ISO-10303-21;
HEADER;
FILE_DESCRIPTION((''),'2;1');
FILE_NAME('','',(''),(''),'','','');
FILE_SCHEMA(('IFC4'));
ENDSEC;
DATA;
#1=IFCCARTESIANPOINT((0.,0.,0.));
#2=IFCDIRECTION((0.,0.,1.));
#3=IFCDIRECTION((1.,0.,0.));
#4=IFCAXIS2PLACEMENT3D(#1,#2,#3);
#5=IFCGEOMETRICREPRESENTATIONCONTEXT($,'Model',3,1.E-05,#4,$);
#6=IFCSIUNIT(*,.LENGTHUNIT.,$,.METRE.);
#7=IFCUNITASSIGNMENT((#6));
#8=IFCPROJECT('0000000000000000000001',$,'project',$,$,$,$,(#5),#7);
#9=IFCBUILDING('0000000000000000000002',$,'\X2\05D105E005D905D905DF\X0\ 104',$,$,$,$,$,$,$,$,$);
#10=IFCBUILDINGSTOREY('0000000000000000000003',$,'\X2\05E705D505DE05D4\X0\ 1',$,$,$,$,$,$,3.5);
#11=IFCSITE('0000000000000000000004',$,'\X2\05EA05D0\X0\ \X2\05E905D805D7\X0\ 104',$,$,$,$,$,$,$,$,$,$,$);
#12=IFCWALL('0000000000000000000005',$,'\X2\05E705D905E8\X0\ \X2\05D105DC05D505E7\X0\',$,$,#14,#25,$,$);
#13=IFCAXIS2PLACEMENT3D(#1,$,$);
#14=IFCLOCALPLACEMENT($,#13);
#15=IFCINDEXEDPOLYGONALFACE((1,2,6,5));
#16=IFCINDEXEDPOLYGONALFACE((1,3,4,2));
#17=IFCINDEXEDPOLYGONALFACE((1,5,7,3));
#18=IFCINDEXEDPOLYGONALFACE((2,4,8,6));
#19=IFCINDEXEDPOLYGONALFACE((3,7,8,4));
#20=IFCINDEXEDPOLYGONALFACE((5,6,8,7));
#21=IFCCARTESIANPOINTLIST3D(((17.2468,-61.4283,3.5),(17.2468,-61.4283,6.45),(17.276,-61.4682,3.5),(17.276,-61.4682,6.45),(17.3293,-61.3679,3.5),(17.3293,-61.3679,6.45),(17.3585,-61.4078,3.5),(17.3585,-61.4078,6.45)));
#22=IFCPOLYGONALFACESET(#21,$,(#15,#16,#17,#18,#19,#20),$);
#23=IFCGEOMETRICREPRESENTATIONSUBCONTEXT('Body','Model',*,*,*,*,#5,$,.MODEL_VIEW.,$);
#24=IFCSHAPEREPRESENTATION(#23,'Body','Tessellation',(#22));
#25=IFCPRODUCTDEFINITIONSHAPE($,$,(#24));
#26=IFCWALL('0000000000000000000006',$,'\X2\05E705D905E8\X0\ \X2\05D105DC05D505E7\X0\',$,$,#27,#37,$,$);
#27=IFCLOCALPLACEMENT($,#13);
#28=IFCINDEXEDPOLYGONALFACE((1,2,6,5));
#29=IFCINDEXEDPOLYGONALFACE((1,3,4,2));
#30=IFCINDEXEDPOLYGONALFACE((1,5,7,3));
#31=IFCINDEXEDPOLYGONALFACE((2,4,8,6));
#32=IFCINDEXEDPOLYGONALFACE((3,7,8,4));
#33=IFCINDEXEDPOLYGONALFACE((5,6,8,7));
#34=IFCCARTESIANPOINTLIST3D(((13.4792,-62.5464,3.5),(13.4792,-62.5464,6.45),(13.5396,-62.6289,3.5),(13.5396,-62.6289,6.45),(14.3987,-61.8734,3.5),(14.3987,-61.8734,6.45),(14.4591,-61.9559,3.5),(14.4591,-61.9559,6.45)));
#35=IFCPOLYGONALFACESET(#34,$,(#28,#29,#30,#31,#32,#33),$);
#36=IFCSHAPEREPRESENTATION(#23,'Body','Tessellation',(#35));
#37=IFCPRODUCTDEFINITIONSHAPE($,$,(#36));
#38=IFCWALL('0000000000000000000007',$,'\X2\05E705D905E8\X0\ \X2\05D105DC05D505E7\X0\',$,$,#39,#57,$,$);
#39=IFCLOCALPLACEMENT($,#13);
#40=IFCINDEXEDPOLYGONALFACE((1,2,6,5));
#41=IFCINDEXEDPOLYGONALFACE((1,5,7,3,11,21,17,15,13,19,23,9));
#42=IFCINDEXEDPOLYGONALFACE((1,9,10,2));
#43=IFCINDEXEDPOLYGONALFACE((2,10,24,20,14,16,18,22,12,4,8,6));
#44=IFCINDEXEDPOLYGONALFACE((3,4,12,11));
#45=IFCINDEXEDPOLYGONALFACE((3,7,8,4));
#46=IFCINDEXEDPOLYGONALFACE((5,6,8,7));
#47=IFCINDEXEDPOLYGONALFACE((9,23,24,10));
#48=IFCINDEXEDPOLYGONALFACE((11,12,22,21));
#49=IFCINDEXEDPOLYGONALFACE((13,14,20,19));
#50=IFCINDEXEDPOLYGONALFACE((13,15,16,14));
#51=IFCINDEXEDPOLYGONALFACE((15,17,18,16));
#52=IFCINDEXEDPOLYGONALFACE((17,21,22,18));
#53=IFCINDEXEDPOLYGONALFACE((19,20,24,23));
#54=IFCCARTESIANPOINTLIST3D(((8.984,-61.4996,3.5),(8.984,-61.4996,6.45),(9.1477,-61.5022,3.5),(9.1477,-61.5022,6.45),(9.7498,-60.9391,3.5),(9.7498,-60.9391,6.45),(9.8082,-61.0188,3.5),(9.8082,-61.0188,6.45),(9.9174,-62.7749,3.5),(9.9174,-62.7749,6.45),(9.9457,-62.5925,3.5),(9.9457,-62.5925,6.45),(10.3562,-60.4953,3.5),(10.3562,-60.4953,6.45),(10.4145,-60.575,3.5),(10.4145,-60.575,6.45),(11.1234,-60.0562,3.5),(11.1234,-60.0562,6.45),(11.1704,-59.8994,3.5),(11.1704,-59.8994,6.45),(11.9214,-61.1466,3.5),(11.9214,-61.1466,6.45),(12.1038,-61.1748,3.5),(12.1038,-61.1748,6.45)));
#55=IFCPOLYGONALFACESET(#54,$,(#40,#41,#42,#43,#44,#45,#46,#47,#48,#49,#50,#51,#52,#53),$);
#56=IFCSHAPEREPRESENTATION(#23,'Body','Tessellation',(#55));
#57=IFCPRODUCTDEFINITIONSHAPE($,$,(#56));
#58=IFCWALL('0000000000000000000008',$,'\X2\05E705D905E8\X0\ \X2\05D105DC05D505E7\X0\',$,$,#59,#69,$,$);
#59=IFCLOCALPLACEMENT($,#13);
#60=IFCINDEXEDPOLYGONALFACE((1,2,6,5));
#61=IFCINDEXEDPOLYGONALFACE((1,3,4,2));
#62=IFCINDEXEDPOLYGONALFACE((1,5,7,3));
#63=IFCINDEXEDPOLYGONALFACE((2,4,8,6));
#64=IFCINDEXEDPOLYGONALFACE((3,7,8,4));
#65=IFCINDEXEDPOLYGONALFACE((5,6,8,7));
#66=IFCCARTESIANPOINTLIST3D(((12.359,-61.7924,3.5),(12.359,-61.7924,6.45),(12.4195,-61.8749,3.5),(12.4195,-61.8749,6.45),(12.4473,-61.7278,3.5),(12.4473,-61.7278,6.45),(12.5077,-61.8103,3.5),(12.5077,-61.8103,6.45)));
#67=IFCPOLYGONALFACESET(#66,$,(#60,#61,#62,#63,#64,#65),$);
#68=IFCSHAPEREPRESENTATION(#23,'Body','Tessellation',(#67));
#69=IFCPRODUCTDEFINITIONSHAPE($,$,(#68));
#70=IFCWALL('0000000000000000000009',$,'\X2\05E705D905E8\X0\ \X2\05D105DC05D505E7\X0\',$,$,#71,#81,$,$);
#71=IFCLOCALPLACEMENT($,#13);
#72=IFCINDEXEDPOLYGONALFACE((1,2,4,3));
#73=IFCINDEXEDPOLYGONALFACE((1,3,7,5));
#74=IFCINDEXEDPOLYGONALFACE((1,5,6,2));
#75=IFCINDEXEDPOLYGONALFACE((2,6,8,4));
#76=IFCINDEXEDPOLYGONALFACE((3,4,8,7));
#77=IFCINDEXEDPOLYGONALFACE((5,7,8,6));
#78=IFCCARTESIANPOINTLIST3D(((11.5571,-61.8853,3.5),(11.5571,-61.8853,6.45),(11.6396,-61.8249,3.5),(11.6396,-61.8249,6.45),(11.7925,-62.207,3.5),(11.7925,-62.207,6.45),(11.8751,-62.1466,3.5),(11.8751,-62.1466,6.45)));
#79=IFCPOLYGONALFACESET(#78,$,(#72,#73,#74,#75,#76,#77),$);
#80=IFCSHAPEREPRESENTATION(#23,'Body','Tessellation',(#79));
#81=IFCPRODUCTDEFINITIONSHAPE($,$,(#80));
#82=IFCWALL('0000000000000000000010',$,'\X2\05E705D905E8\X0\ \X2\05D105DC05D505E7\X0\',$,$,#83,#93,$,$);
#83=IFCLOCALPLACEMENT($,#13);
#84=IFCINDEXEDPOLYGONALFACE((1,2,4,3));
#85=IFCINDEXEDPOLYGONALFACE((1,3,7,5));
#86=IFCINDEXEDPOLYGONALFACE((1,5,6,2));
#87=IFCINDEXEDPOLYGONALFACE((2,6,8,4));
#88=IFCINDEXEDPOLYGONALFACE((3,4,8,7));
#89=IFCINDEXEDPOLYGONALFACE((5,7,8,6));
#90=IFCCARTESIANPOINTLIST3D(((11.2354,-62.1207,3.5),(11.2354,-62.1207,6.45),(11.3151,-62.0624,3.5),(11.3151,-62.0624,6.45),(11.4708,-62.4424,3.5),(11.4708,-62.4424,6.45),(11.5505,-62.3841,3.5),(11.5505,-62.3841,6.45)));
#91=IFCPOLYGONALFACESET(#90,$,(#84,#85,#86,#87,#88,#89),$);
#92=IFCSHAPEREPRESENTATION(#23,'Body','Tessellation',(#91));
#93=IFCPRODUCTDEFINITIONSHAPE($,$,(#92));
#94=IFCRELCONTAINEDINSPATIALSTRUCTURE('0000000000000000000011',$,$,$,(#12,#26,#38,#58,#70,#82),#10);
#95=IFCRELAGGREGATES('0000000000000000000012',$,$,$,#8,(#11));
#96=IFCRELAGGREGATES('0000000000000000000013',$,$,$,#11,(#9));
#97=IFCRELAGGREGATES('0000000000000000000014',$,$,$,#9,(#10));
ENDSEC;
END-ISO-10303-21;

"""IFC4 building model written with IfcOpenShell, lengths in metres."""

from ifc_helpers import new_model, si_unit, frame, origin_with_axes, context, subcontext, project, spatial, polyline, outline, extrude, element, save


model = new_model("IFC4")

# Units and contexts
model_context = context("Model", 3, precision=1e-05, world=origin_with_axes())
body_context = subcontext(model_context, "Body", "Model", "MODEL_VIEW")
ifc_project = project(units=[si_unit("LENGTHUNIT", "METRE")], contexts=[model_context])

# Site, building, storey
site = spatial("IfcSite", under=ifc_project, Name="תא שטח 104")
building = spatial("IfcBuilding", under=site, Name="בניין 104")
storey = spatial("IfcBuildingStorey", under=building, Name="קומה 1", Elevation=3.5)

# Walls
element("IfcWall", 1, inside=storey, Name="קיר בלוק", context=body_context, shape_type="SweptSolid", body=[
    extrude(outline(polyline([(17.3585, -61.4078), (17.3293, -61.3679), (17.2468, -61.4283), (17.276, -61.4682), (17.3585, -61.4078)])), frame((0.0, 0.0, 3.5)), (0.0, 0.0, 1.0), 2.95),
])
element("IfcWall", 2, inside=storey, Name="קיר בלוק", context=body_context, shape_type="SweptSolid", body=[
    extrude(outline(polyline([(14.4591, -61.9559), (14.3987, -61.8734), (13.4792, -62.5464), (13.5396, -62.6289), (14.4591, -61.9559)])), frame((0.0, 0.0, 3.5)), (0.0, 0.0, 1.0), 2.95),
])
element("IfcWall", 3, inside=storey, Name="קיר בלוק", context=body_context, shape_type="SweptSolid", body=[
    extrude(outline(polyline([(11.1704, -59.8994), (10.3562, -60.4953), (10.4145, -60.575), (11.1234, -60.0562), (11.9214, -61.1466), (9.9457, -62.5925), (9.1477, -61.5022), (9.8082, -61.0188), (9.7498, -60.9391), (8.984, -61.4996), (9.9174, -62.7749), (12.1038, -61.1748), (11.1704, -59.8994)])), frame((0.0, 0.0, 3.5)), (0.0, 0.0, 1.0), 2.95),
])
element("IfcWall", 4, inside=storey, Name="קיר בלוק", context=body_context, shape_type="SweptSolid", body=[
    extrude(outline(polyline([(12.4473, -61.7278), (12.359, -61.7924), (12.4195, -61.8749), (12.5077, -61.8103), (12.4473, -61.7278)])), frame((0.0, 0.0, 3.5)), (0.0, 0.0, 1.0), 2.95),
])
element("IfcWall", 5, inside=storey, Name="קיר בלוק", context=body_context, shape_type="SweptSolid", body=[
    extrude(outline(polyline([(11.6396, -61.8249), (11.5571, -61.8853), (11.7925, -62.207), (11.8751, -62.1466), (11.6396, -61.8249)])), frame((0.0, 0.0, 3.5)), (0.0, 0.0, 1.0), 2.95),
])
element("IfcWall", 6, inside=storey, Name="קיר בלוק", context=body_context, shape_type="SweptSolid", body=[
    extrude(outline(polyline([(11.3151, -62.0624), (11.2354, -62.1207), (11.4708, -62.4424), (11.5505, -62.3841), (11.3151, -62.0624)])), frame((0.0, 0.0, 3.5)), (0.0, 0.0, 1.0), 2.95),
])

save(model, "model.ifc")
